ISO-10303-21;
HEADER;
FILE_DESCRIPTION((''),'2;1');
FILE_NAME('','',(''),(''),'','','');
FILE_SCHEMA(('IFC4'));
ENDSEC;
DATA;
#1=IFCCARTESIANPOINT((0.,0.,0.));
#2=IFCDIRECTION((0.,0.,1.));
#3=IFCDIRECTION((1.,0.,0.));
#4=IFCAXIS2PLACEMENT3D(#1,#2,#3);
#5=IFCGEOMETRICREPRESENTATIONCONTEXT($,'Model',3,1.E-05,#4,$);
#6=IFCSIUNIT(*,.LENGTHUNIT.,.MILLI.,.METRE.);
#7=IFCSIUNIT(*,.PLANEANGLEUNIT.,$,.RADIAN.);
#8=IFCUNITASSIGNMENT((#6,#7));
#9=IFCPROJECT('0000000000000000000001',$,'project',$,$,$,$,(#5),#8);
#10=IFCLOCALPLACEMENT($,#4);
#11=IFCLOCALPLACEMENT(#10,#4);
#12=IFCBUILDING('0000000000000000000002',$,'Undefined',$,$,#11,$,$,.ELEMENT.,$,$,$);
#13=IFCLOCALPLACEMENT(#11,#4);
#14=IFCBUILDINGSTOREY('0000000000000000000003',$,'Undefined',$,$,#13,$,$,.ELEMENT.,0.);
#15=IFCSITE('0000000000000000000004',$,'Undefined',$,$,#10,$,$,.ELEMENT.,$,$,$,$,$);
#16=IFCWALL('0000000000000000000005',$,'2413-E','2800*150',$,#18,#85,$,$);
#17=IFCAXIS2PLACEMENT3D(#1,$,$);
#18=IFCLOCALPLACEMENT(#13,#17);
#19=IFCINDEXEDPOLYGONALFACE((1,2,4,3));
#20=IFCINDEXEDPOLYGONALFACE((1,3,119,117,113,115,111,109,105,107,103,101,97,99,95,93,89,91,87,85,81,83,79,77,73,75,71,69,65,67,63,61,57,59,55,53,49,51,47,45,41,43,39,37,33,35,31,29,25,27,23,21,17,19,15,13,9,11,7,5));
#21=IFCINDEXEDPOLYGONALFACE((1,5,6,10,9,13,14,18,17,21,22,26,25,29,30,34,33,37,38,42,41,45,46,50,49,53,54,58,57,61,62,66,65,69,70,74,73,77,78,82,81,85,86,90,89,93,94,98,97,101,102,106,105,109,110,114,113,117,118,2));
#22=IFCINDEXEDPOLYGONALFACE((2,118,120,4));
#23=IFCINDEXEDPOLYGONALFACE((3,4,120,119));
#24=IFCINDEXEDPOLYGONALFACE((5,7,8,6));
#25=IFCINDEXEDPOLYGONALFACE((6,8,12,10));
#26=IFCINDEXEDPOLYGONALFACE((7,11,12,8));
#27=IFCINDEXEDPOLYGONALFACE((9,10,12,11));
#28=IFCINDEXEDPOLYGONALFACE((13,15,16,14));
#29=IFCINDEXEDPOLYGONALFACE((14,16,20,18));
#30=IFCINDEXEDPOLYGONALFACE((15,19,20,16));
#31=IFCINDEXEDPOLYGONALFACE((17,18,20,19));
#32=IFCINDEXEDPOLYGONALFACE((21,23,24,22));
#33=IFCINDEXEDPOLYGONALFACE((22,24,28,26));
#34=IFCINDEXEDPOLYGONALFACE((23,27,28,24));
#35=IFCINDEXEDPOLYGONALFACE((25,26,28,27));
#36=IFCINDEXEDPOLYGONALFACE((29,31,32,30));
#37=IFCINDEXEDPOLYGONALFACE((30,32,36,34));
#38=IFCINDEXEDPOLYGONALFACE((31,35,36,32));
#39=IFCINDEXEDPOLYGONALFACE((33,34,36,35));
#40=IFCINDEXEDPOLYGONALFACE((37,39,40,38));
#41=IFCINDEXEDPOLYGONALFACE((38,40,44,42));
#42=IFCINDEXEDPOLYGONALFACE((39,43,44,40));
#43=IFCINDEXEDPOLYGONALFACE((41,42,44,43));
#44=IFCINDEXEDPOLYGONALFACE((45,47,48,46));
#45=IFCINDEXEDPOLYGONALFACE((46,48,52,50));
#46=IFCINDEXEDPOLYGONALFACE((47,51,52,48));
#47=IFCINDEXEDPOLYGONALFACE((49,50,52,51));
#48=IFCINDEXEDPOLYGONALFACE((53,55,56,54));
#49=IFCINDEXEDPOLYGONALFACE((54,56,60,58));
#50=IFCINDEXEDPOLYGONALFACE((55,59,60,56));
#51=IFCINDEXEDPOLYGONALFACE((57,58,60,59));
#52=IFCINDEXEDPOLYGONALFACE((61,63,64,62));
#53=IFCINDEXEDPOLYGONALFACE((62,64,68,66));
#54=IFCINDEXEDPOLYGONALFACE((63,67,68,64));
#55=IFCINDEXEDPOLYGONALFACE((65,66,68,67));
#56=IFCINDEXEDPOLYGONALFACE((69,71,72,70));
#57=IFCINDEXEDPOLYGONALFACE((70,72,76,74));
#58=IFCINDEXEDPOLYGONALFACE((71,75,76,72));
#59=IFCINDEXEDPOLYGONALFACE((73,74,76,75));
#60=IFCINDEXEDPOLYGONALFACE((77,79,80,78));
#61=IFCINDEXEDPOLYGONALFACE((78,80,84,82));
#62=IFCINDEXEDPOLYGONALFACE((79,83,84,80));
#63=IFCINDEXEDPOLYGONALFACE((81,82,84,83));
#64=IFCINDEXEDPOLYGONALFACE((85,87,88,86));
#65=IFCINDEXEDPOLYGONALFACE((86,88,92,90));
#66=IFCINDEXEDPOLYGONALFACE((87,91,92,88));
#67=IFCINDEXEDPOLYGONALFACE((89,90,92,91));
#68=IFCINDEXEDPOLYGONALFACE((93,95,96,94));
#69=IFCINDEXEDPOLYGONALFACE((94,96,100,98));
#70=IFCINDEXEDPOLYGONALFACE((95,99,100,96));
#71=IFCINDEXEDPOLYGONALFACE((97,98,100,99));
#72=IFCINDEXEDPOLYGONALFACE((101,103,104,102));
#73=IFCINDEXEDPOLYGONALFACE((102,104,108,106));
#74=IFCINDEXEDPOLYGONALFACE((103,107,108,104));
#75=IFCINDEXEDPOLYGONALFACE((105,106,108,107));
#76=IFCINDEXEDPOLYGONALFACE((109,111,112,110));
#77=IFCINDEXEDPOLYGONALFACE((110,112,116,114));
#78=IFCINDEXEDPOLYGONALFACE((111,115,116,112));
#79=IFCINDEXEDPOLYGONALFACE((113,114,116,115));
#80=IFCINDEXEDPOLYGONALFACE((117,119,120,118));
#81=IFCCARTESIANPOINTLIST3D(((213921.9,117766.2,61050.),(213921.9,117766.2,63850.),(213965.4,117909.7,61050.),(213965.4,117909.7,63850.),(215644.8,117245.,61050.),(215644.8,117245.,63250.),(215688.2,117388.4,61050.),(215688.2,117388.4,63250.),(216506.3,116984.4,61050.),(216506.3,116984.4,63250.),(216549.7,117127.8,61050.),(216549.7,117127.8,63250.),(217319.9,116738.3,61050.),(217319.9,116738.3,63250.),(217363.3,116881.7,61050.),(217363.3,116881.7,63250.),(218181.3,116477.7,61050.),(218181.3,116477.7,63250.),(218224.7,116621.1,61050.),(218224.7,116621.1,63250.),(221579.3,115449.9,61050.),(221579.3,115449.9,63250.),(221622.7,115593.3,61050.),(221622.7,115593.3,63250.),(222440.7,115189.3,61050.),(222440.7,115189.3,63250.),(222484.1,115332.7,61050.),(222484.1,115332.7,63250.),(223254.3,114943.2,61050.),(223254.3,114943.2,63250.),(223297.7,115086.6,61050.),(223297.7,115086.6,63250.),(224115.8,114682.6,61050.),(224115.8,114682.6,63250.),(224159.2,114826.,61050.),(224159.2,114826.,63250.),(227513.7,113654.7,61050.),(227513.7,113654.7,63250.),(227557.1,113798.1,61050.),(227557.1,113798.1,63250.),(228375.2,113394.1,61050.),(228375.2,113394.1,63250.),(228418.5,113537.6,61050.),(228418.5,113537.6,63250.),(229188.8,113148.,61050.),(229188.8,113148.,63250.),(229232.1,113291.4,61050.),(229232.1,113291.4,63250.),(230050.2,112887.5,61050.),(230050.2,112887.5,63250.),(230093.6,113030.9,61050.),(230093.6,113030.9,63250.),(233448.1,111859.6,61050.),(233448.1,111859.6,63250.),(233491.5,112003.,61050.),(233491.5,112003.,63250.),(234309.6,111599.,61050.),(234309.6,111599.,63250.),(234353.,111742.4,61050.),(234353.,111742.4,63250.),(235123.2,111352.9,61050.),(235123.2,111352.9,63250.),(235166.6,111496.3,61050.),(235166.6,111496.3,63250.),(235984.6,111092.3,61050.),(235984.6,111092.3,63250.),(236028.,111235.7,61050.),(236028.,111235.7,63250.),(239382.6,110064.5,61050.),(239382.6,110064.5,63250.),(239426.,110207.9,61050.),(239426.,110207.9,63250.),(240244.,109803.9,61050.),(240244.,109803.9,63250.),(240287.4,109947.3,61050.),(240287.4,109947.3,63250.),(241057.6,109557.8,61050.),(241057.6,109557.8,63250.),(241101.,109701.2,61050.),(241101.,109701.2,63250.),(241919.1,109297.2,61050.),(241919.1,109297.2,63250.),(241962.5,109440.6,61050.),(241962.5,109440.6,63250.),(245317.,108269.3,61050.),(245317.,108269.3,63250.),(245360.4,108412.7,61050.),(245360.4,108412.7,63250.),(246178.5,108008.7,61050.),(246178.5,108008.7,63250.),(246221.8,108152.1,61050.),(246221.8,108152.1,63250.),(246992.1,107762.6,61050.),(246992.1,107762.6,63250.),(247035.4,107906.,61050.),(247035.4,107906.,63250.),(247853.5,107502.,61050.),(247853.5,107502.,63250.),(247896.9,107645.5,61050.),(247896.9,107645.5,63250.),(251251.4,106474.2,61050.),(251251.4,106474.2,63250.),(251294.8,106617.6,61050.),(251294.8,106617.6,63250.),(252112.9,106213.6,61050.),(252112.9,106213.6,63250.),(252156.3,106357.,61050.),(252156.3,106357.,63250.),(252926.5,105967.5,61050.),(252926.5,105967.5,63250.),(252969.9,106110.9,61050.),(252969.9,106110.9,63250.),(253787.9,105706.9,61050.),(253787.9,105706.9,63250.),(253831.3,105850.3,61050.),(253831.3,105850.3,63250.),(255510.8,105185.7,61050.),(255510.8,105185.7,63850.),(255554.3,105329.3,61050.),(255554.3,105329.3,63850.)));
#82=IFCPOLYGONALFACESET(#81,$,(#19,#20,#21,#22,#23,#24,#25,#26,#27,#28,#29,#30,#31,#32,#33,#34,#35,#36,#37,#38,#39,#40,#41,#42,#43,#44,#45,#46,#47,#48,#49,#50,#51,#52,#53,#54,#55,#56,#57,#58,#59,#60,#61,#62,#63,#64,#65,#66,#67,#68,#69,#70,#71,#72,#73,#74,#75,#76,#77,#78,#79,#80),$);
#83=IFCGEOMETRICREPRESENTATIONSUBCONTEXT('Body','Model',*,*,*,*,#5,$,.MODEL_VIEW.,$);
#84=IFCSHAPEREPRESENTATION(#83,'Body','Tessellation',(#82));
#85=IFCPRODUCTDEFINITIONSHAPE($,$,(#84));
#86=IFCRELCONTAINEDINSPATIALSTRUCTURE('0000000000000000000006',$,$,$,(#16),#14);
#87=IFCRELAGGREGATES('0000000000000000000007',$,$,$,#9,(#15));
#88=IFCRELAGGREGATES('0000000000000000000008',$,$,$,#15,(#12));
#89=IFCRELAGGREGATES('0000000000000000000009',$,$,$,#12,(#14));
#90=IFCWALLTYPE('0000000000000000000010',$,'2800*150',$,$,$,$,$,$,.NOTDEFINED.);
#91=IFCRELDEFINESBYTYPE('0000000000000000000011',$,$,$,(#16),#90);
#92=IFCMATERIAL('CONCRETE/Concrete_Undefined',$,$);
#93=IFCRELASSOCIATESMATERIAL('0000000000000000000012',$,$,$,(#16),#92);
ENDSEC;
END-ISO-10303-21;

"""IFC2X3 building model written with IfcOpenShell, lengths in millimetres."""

from ifc_helpers import new_model, si_unit, frame, frame_2d, origin_with_axes, place, context, subcontext, project, spatial, rectangle, extrude, boolean, material, type_object, element, save


model = new_model("IFC2X3")

# Units and contexts
model_context = context("Model", 3, precision=1e-05, world=origin_with_axes())
body_context = subcontext(model_context, "Body", "Model", "MODEL_VIEW")
ifc_project = project(units=[si_unit("LENGTHUNIT", "METRE", prefix="MILLI"), si_unit("PLANEANGLEUNIT", "RADIAN")], contexts=[model_context])

# Site, building, storey
site_placement = place(None, origin_with_axes())
site = spatial("IfcSite", under=ifc_project, at=site_placement, Name="Undefined", CompositionType="ELEMENT")
building_placement = place(site_placement, origin_with_axes())
building = spatial("IfcBuilding", under=site, at=building_placement, Name="Undefined", CompositionType="ELEMENT")
storey_placement = place(building_placement, origin_with_axes())
storey = spatial("IfcBuildingStorey", under=building, at=storey_placement, Name="Undefined", CompositionType="ELEMENT", Elevation=0.0)

# Shared definitions
ifc_material_1 = material(Name="CONCRETE/Concrete_Undefined")

# Wall
wall_type_1 = type_object("IfcWallType", Name="2800*150", PredefinedType="NOTDEFINED")
wall_1_placement = place(storey_placement, frame((213943.7, 117838.0, 61050.0), z_axis=(0.0, 0.0, 1.0), x_axis=(0.957167, -0.289538, 0.0)))
solid_1 = boolean("DIFFERENCE", boolean("DIFFERENCE", boolean("DIFFERENCE", boolean("DIFFERENCE", boolean("DIFFERENCE", boolean("DIFFERENCE", boolean("DIFFERENCE", boolean("DIFFERENCE", extrude(rectangle(XDim=43450.0, YDim=150.0, at=frame_2d((0.0, 21725.0), x_axis=(0.0, -1.0))), frame((0.0, 0.0, 0.0), z_axis=(0.0, 0.0, 1.0), x_axis=(0.0, -1.0, 0.0)), (0.0, 0.0, 1.0), 2800.0), extrude(rectangle(XDim=900.0, YDim=150.0, at=frame_2d((0.0, 450.0), x_axis=(0.0, -1.0))), frame((39000.0, -0.2, 0.0), z_axis=(0.0, 0.0, 1.0), x_axis=(-0.000003, -1.0, 0.0)), (0.0, 0.0, 1.0), 2200.0)), extrude(rectangle(XDim=900.0, YDim=150.0, at=frame_2d((0.0, 450.0), x_axis=(0.0, -1.0))), frame((40750.0, -0.2, 0.0), z_axis=(0.0, 0.0, 1.0), x_axis=(-0.000003, -1.0, 0.0)), (0.0, 0.0, 1.0), 2200.0)), extrude(rectangle(XDim=900.0, YDim=150.0, at=frame_2d((0.0, 450.0), x_axis=(0.0, -1.0))), frame((32800.0, -0.2, 0.0), z_axis=(0.0, 0.0, 1.0), x_axis=(-0.000003, -1.0, 0.0)), (0.0, 0.0, 1.0), 2200.0)), extrude(rectangle(XDim=900.0, YDim=150.0, at=frame_2d((0.0, 450.0), x_axis=(0.0, -1.0))), frame((34550.0, -0.2, 0.0), z_axis=(0.0, 0.0, 1.0), x_axis=(-0.000003, -1.0, 0.0)), (0.0, 0.0, 1.0), 2200.0)), extrude(rectangle(XDim=900.0, YDim=150.0, at=frame_2d((0.0, 450.0), x_axis=(0.0, -1.0))), frame((26600.0, -0.2, 0.0), z_axis=(0.0, 0.0, 1.0), x_axis=(-0.000003, -1.0, 0.0)), (0.0, 0.0, 1.0), 2200.0)), extrude(rectangle(XDim=900.0, YDim=150.0, at=frame_2d((0.0, 450.0), x_axis=(0.0, -1.0))), frame((28350.0, -0.2, 0.0), z_axis=(0.0, 0.0, 1.0), x_axis=(-0.000003, -1.0, 0.0)), (0.0, 0.0, 1.0), 2200.0)), extrude(rectangle(XDim=900.0, YDim=150.0, at=frame_2d((0.0, 450.0), x_axis=(0.0, -1.0))), frame((20400.0, -0.2, 0.0), z_axis=(0.0, 0.0, 1.0), x_axis=(-0.000003, -1.0, 0.0)), (0.0, 0.0, 1.0), 2200.0)), extrude(rectangle(XDim=900.0, YDim=150.0, at=frame_2d((0.0, 450.0), x_axis=(0.0, -1.0))), frame((22150.0, -0.2, 0.0), z_axis=(0.0, 0.0, 1.0), x_axis=(-0.000003, -1.0, 0.0)), (0.0, 0.0, 1.0), 2200.0))
element("IfcWall", 1, at=wall_1_placement, inside=storey, type_object=wall_type_1, material=ifc_material_1, Name="2413-E", Description="2800*150", context=body_context, shape_type="CSG", body=[
    boolean("DIFFERENCE", boolean("DIFFERENCE", boolean("DIFFERENCE", boolean("DIFFERENCE", boolean("DIFFERENCE", boolean("DIFFERENCE", solid_1, extrude(rectangle(XDim=900.0, YDim=150.0, at=frame_2d((0.0, 450.0), x_axis=(0.0, -1.0))), frame((14200.0, -0.2, 0.0), z_axis=(0.0, 0.0, 1.0), x_axis=(-0.000003, -1.0, 0.0)), (0.0, 0.0, 1.0), 2200.0)), extrude(rectangle(XDim=900.0, YDim=150.0, at=frame_2d((0.0, 450.0), x_axis=(0.0, -1.0))), frame((15950.0, -0.2, 0.0), z_axis=(0.0, 0.0, 1.0), x_axis=(-0.000003, -1.0, 0.0)), (0.0, 0.0, 1.0), 2200.0)), extrude(rectangle(XDim=900.0, YDim=150.0, at=frame_2d((0.0, 450.0), x_axis=(0.0, -1.0))), frame((8000.0, -0.2, 0.0), z_axis=(0.0, 0.0, 1.0), x_axis=(-0.000003, -1.0, 0.0)), (0.0, 0.0, 1.0), 2200.0)), extrude(rectangle(XDim=900.0, YDim=150.0, at=frame_2d((0.0, 450.0), x_axis=(0.0, -1.0))), frame((9750.0, -0.2, 0.0), z_axis=(0.0, 0.0, 1.0), x_axis=(-0.000003, -1.0, 0.0)), (0.0, 0.0, 1.0), 2200.0)), extrude(rectangle(XDim=900.0, YDim=150.0, at=frame_2d((0.0, 450.0), x_axis=(0.0, -1.0))), frame((1800.0, -0.2, 0.0), z_axis=(0.0, 0.0, 1.0), x_axis=(-0.000003, -1.0, 0.0)), (0.0, 0.0, 1.0), 2200.0)), extrude(rectangle(XDim=900.0, YDim=150.0, at=frame_2d((0.0, 450.0), x_axis=(0.0, -1.0))), frame((3550.0, -0.2, 0.0), z_axis=(0.0, 0.0, 1.0), x_axis=(-0.000003, -1.0, 0.0)), (0.0, 0.0, 1.0), 2200.0)),
])

save(model, "model.ifc")
